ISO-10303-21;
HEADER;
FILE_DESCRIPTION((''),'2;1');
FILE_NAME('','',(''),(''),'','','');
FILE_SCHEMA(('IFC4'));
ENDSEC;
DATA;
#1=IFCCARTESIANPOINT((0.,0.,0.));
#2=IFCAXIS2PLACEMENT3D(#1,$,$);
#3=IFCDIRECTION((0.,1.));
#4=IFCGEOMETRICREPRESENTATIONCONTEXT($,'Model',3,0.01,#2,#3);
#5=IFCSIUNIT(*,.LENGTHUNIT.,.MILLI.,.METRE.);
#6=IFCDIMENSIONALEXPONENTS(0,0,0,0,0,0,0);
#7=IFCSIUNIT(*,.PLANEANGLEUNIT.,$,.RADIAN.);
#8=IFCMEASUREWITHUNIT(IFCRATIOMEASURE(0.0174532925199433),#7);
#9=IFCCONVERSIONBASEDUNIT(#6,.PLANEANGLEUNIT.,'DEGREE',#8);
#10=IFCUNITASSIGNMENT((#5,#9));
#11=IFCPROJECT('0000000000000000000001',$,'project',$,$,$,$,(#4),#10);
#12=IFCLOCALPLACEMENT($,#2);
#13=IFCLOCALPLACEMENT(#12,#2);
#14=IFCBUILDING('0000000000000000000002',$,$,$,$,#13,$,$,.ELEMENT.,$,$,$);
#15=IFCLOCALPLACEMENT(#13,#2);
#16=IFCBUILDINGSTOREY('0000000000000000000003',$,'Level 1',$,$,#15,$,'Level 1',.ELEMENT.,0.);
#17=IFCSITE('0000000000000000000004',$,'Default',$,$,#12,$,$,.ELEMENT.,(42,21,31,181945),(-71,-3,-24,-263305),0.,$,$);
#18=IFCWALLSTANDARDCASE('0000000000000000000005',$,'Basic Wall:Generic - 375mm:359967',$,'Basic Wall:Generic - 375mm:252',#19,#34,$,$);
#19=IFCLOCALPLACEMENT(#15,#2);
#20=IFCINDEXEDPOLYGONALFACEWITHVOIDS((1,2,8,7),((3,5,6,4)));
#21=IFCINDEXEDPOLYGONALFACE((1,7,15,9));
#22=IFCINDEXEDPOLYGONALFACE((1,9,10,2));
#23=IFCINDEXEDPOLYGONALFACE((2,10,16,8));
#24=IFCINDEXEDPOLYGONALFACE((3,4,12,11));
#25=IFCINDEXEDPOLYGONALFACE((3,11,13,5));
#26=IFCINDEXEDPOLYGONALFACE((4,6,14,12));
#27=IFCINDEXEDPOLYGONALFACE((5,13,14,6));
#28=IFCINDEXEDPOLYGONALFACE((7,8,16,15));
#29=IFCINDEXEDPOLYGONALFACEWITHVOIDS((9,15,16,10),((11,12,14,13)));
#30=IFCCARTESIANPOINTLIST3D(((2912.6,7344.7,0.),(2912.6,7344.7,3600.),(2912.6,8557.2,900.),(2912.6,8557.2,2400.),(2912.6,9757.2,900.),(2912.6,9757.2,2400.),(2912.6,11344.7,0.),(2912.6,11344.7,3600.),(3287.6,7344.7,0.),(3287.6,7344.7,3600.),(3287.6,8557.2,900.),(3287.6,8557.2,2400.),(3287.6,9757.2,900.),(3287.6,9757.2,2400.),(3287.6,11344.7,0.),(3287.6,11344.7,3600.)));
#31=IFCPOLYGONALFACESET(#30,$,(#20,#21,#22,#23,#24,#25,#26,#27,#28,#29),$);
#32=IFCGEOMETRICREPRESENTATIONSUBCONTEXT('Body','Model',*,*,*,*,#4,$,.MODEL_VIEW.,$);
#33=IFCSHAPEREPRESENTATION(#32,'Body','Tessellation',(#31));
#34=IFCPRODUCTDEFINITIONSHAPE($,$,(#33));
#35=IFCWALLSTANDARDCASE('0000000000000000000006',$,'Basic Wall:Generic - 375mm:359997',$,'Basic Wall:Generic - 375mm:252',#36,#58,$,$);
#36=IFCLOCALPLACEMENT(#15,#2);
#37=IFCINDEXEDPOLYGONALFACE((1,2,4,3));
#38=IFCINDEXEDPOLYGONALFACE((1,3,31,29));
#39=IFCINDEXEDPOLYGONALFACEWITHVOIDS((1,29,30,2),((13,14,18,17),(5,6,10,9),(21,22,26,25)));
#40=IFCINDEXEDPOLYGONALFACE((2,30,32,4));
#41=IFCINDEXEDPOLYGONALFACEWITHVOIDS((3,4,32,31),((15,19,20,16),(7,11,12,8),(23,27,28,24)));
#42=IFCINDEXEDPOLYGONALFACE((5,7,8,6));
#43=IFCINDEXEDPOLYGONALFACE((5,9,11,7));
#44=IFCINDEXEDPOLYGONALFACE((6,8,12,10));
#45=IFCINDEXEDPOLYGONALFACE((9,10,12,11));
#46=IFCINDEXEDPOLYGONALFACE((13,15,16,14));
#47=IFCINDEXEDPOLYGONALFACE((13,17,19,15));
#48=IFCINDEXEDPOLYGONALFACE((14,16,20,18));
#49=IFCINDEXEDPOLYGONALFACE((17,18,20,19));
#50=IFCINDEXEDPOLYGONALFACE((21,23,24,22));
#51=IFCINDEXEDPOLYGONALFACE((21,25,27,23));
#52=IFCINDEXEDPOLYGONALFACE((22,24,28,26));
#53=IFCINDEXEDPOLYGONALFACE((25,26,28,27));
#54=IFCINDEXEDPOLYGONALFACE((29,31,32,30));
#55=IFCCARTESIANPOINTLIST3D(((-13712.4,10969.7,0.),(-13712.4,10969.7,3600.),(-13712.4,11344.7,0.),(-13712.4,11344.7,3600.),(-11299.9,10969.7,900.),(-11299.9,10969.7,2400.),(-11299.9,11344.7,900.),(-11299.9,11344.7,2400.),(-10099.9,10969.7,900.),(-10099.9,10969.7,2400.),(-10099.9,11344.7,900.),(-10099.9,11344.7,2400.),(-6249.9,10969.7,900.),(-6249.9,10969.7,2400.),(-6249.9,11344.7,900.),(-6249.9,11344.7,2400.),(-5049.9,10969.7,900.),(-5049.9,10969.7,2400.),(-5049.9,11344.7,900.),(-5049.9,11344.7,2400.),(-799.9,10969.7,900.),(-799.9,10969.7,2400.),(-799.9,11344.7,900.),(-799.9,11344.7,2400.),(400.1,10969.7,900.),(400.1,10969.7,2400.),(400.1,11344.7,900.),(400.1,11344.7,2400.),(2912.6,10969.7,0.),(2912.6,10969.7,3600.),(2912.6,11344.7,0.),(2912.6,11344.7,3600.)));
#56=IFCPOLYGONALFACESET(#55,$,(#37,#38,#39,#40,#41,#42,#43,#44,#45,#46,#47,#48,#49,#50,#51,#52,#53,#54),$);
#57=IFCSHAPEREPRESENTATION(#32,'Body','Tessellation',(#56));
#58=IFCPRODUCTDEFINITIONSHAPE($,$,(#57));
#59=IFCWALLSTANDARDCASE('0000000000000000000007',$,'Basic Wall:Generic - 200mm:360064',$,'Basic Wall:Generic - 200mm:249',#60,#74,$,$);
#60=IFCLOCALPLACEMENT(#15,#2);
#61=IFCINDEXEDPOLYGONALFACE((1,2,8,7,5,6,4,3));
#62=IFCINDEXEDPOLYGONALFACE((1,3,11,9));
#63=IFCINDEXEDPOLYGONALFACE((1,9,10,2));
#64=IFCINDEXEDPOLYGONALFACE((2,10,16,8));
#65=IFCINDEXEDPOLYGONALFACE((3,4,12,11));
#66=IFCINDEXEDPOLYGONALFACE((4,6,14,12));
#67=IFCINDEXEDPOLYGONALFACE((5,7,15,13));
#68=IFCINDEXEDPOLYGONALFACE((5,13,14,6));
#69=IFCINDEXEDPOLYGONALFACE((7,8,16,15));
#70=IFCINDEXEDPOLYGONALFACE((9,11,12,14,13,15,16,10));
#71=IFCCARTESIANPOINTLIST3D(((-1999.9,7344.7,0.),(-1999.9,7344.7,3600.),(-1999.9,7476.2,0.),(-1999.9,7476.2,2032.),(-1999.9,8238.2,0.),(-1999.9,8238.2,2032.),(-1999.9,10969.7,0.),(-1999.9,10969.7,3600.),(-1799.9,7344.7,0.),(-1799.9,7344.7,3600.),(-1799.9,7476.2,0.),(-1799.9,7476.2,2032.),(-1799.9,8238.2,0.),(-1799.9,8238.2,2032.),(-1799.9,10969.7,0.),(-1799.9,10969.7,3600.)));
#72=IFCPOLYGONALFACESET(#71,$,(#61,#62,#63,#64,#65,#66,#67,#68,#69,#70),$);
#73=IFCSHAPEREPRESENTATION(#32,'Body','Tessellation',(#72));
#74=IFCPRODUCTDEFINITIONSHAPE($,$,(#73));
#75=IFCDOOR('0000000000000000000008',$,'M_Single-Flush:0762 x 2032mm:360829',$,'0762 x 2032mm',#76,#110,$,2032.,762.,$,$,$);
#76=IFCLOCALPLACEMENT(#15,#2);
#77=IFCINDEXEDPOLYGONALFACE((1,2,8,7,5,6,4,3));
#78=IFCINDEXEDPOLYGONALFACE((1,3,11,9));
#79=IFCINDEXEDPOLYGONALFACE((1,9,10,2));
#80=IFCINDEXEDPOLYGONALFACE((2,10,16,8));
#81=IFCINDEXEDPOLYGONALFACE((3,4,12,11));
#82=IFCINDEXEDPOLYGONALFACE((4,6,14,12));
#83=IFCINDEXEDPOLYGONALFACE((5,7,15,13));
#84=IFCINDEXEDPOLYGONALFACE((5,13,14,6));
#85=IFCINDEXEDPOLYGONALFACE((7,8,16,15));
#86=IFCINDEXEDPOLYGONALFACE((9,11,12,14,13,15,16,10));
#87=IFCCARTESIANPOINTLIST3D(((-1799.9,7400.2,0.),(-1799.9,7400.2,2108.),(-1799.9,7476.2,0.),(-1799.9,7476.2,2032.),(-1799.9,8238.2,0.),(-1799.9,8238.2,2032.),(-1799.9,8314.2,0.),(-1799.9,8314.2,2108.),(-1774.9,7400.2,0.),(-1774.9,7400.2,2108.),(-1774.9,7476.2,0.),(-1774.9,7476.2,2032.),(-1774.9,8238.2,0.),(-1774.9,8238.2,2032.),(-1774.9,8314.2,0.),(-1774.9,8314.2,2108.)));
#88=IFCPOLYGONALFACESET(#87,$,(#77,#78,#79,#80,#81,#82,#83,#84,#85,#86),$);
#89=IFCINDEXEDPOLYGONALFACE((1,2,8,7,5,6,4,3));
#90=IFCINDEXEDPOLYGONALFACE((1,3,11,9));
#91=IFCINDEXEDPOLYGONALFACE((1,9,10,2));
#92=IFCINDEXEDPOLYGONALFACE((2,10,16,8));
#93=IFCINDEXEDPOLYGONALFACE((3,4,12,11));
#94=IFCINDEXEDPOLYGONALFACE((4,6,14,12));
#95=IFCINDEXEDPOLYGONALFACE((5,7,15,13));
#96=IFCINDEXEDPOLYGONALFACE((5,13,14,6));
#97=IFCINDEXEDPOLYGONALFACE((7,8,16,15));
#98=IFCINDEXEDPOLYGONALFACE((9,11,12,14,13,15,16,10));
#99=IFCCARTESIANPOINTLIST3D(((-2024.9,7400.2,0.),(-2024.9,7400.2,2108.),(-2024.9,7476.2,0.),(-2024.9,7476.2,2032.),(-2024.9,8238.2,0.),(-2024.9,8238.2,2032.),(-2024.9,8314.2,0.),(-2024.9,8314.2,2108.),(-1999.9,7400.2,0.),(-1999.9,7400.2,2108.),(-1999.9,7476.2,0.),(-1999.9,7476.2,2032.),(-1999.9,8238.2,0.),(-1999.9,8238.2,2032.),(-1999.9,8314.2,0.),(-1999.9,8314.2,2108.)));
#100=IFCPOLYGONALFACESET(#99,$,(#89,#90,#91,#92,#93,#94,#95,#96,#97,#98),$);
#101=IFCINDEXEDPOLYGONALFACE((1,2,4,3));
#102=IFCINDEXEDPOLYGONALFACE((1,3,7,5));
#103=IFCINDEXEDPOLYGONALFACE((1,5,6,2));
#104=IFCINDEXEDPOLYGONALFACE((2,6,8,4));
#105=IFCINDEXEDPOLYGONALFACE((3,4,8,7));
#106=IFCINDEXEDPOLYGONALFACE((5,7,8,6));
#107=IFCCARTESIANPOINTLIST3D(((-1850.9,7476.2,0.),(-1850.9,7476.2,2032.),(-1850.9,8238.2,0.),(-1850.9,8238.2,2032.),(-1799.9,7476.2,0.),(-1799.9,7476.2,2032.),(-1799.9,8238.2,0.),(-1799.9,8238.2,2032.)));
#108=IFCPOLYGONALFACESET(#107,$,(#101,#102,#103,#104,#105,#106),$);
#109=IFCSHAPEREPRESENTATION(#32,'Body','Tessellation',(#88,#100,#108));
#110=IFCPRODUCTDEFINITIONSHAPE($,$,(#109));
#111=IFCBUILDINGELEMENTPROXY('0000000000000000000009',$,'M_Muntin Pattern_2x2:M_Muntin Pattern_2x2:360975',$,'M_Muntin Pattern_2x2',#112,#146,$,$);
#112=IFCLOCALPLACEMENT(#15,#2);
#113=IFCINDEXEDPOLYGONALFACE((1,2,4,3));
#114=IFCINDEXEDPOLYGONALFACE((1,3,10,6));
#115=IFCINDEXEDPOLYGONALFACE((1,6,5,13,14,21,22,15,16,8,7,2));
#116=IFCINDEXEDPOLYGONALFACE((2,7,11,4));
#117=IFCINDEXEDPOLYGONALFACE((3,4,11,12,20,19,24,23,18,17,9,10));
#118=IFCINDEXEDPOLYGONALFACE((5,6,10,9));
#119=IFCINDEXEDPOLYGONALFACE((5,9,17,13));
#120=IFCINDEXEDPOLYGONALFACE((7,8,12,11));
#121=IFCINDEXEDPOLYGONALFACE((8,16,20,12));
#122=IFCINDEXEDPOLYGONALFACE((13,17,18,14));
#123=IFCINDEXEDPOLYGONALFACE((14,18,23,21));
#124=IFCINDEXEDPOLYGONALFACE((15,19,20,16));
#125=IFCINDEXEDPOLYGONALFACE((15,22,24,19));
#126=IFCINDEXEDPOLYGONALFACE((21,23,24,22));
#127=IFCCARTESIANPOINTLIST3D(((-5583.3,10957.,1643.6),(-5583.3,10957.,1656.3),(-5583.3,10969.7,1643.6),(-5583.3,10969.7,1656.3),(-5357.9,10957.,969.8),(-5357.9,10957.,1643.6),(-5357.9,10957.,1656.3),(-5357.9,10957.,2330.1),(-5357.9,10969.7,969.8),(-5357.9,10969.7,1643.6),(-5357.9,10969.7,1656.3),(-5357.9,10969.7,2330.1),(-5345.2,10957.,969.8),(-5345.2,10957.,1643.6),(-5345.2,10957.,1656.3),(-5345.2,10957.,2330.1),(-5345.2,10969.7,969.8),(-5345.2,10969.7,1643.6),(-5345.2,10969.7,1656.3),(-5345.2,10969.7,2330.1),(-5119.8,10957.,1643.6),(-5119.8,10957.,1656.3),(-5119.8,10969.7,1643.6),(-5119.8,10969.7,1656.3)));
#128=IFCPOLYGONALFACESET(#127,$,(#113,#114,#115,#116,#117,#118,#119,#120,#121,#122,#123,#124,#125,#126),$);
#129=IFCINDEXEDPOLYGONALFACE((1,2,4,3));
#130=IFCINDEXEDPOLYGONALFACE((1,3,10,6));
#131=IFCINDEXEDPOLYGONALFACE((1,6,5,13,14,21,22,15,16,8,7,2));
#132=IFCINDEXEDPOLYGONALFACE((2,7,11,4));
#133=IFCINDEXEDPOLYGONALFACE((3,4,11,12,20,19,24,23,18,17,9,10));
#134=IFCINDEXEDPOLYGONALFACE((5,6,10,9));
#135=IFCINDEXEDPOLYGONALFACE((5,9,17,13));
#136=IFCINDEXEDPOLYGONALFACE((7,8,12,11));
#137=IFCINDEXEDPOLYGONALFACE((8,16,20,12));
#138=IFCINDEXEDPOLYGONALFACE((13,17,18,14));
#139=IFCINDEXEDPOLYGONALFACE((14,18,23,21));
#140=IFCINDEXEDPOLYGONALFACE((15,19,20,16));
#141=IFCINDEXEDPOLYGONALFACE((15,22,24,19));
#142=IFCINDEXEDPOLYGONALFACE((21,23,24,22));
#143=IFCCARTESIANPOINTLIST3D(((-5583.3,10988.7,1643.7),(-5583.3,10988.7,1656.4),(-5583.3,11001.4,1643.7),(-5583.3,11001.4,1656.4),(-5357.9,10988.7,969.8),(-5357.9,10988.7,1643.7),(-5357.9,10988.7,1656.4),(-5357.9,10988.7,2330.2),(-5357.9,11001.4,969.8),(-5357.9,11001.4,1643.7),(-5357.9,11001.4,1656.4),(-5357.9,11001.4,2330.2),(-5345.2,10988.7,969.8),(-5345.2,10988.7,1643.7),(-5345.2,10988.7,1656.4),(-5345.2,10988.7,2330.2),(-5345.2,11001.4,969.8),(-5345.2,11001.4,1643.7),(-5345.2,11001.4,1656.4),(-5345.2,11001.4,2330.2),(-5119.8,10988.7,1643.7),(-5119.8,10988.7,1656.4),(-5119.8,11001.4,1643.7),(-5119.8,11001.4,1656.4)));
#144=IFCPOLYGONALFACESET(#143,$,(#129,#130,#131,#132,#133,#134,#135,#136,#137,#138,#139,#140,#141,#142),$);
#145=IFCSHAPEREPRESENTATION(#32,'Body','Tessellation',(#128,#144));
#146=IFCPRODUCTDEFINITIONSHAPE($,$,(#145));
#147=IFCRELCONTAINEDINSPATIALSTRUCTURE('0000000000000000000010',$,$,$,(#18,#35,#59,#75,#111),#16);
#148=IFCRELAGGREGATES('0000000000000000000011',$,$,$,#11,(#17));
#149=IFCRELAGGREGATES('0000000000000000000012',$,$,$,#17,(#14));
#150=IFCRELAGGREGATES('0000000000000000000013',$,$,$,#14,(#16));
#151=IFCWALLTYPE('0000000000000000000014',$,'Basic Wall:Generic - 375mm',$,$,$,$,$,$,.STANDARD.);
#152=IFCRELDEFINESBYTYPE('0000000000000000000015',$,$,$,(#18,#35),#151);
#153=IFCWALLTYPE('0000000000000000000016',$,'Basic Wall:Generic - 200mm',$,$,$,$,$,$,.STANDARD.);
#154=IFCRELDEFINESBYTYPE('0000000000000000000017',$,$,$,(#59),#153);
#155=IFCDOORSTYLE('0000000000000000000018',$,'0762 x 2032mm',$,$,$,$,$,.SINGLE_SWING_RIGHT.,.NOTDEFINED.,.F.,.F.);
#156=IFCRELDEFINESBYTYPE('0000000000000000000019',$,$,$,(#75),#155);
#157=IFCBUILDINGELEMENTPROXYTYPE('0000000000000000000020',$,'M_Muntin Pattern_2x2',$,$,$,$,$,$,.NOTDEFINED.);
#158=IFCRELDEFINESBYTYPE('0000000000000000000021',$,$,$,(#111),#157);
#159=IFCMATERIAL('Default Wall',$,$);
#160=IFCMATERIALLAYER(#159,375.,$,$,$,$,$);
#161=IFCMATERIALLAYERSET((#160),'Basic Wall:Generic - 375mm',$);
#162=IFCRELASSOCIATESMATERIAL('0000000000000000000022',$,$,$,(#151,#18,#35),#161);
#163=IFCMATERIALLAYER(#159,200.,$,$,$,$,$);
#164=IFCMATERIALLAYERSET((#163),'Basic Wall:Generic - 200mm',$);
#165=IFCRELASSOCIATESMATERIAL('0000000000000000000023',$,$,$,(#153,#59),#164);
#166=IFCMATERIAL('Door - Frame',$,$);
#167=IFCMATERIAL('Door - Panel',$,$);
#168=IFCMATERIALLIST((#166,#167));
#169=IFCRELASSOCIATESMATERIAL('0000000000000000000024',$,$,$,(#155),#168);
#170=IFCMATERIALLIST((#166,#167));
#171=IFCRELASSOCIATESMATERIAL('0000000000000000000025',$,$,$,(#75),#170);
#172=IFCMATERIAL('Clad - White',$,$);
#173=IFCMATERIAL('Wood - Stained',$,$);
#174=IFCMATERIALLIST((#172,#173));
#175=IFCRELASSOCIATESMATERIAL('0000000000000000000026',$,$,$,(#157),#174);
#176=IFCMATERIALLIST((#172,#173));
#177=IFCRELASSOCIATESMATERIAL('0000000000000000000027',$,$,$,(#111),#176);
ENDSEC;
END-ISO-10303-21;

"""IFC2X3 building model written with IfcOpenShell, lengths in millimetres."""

from ifc_helpers import new_model, entity, si_unit, converted_unit, direction, frame, frame_2d, origin, place, context, subcontext, project, spatial, polyline, rectangle, outline, extrude, clip, bounded_halfspace, source, transform, mapped, material, material_list, layer, layer_set, layer_usage, type_object, type_shapes, element, fill, save


model = new_model("IFC2X3")

# Units and contexts
model_context = context("Model", 3, precision=0.01, world=origin(), true_north=direction((0.0, 1.0)))
body_context = subcontext(model_context, "Body", "Model", "MODEL_VIEW")
ifc_project = project(units=[si_unit("LENGTHUNIT", "METRE", prefix="MILLI"), converted_unit("PLANEANGLEUNIT", "DEGREE", entity("IfcRatioMeasure", 0.0174532925199433), si_unit("PLANEANGLEUNIT", "RADIAN"), dimensions=[0, 0, 0, 0, 0, 0, 0])], contexts=[model_context])

# Site, building, storey
site_placement = place(None, origin())
site = spatial("IfcSite", under=ifc_project, at=site_placement, Name="Default", CompositionType="ELEMENT", RefLatitude=(42, 21, 31, 181945), RefLongitude=(-71, -3, -24, -263305), RefElevation=0.0)
building_placement = place(site_placement, origin())
building = spatial("IfcBuilding", under=site, at=building_placement, CompositionType="ELEMENT")
storey_placement = place(building_placement, origin())
storey = spatial("IfcBuildingStorey", under=building, at=storey_placement, Name="Level 1", LongName="Level 1", CompositionType="ELEMENT", Elevation=0.0)

# Wall, opening
ifc_material_1 = material(Name="Default Wall")
ifc_layer_1 = layer(ifc_material_1, 375.0)
ifc_layer_set_1 = layer_set([ifc_layer_1], Name="Basic Wall:Generic - 375mm")
ifc_layer_usage_1 = layer_usage(ifc_layer_set_1, "AXIS2", "NEGATIVE", 187.5)
wall_type_1 = type_object("IfcWallType", Name="Basic Wall:Generic - 375mm", PredefinedType="STANDARD", material=ifc_layer_set_1)
wall_1_placement = place(storey_placement, frame((3100.1, 7344.7, 0.0), z_axis=(0.0, 0.0, 1.0), x_axis=(0.0, 1.0, 0.0)))
wall_1 = element("IfcWallStandardCase", 1, at=wall_1_placement, inside=storey, type_object=wall_type_1, material=ifc_layer_usage_1, Name="Basic Wall:Generic - 375mm:359967", ObjectType="Basic Wall:Generic - 375mm:252", context=body_context, shape_type="Clipping", body=[
    clip(extrude(rectangle(XDim=4000.0, YDim=375.0, at=frame_2d((2000.0, 0.0), x_axis=(-1.0, 0.0))), origin(), (0.0, 0.0, 1.0), 3600.0), bounded_halfspace(frame((0.0, -187.5, 3600.0), z_axis=(0.0, 0.0, -1.0), x_axis=(0.0, -1.0, 0.0)), True, frame((0.0, -187.5, 3600.0)), polyline([(0.0, 0.0), (4000.0, 0.0), (4000.0, 375.0), (3625.0, 375.0), (0.0, 375.0), (0.0, 0.0)]))),
])
opening_1_placement = place(wall_1_placement, frame((1212.5, -187.5, 900.0)))
element("IfcOpeningElement", 2, at=opening_1_placement, cuts=wall_1, ObjectType="Opening", context=body_context, shape_type="SweptSolid", body=[
    extrude(rectangle(XDim=1500.0, YDim=1200.0, at=frame_2d((750.0, 600.0), x_axis=(-1.0, 0.0))), frame((0.0, 0.0, 0.0), z_axis=(0.0, 1.0, 0.0), x_axis=(0.0, 0.0, 1.0)), (0.0, 0.0, 1.0), 375.0),
])

# Wall, openings
ifc_layer_usage_2 = layer_usage(ifc_layer_set_1, "AXIS2", "NEGATIVE", 187.5)
wall_2_placement = place(storey_placement, frame((2912.6, 11157.2, 0.0), z_axis=(0.0, 0.0, 1.0), x_axis=(-1.0, 0.0, 0.0)))
wall_2 = element("IfcWallStandardCase", 3, at=wall_2_placement, inside=storey, type_object=wall_type_1, material=ifc_layer_usage_2, Name="Basic Wall:Generic - 375mm:359997", ObjectType="Basic Wall:Generic - 375mm:252", context=body_context, shape_type="Clipping", body=[
    clip(extrude(rectangle(XDim=16625.0, YDim=375.0, at=frame_2d((8312.5, 0.0), x_axis=(-1.0, 0.0))), origin(), (0.0, 0.0, 1.0), 3600.0), bounded_halfspace(frame((0.0, -187.5, 3600.0), z_axis=(0.0, 0.0, -1.0), x_axis=(-1.0, 0.0, 0.0)), True, frame((0.0, -187.5, 3600.0)), polyline([(0.0, 0.0), (16625.0, 0.0), (16625.0, 375.0), (12412.5, 375.0), (12212.5, 375.0), (4912.5, 375.0), (4712.5, 375.0), (0.0, 375.0), (0.0, 0.0)]))),
])
opening_2_placement = place(wall_2_placement, frame((7962.5, -187.5, 900.0)))
element("IfcOpeningElement", 4, at=opening_2_placement, cuts=wall_2, ObjectType="Opening", context=body_context, shape_type="SweptSolid", body=[
    extrude(rectangle(XDim=1500.0, YDim=1200.0, at=frame_2d((750.0, 600.0), x_axis=(-1.0, 0.0))), frame((0.0, 0.0, 0.0), z_axis=(0.0, 1.0, 0.0), x_axis=(0.0, 0.0, 1.0)), (0.0, 0.0, 1.0), 375.0),
])
opening_3_placement = place(wall_2_placement, frame((2512.5, -187.5, 900.0)))
element("IfcOpeningElement", 5, at=opening_3_placement, cuts=wall_2, ObjectType="Opening", context=body_context, shape_type="SweptSolid", body=[
    extrude(rectangle(XDim=1500.0, YDim=1200.0, at=frame_2d((750.0, 600.0), x_axis=(-1.0, 0.0))), frame((0.0, 0.0, 0.0), z_axis=(0.0, 1.0, 0.0), x_axis=(0.0, 0.0, 1.0)), (0.0, 0.0, 1.0), 375.0),
])
opening_4_placement = place(wall_2_placement, frame((13012.5, -187.5, 900.0)))
element("IfcOpeningElement", 6, at=opening_4_placement, cuts=wall_2, ObjectType="Opening", context=body_context, shape_type="SweptSolid", body=[
    extrude(rectangle(XDim=1500.0, YDim=1200.0, at=frame_2d((750.0, 600.0), x_axis=(-1.0, 0.0))), frame((0.0, 0.0, 0.0), z_axis=(0.0, 1.0, 0.0), x_axis=(0.0, 0.0, 1.0)), (0.0, 0.0, 1.0), 375.0),
])

# Wall, opening, door
ifc_layer_2 = layer(ifc_material_1, 200.0)
ifc_layer_set_2 = layer_set([ifc_layer_2], Name="Basic Wall:Generic - 200mm")
ifc_layer_usage_3 = layer_usage(ifc_layer_set_2, "AXIS2", "NEGATIVE", 100.0)
wall_type_2 = type_object("IfcWallType", Name="Basic Wall:Generic - 200mm", PredefinedType="STANDARD", material=ifc_layer_set_2)
wall_3_placement = place(storey_placement, frame((-1899.9, 10969.7, 0.0), z_axis=(0.0, 0.0, 1.0), x_axis=(0.0, -1.0, 0.0)))
wall_3 = element("IfcWallStandardCase", 7, at=wall_3_placement, inside=storey, type_object=wall_type_2, material=ifc_layer_usage_3, Name="Basic Wall:Generic - 200mm:360064", ObjectType="Basic Wall:Generic - 200mm:249", context=body_context, shape_type="Clipping", body=[
    clip(extrude(rectangle(XDim=3625.0, YDim=200.0, at=frame_2d((1812.5, 0.0), x_axis=(-1.0, 0.0))), origin(), (0.0, 0.0, 1.0), 3600.0), bounded_halfspace(frame((0.0, -100.0, 3600.0), z_axis=(0.0, 0.0, -1.0), x_axis=(0.0, 1.0, 0.0)), True, frame((0.0, -100.0, 3600.0)), polyline([(0.0, 0.0), (3625.0, 0.0), (3625.0, 200.0), (0.0, 200.0), (0.0, 0.0)]))),
])
opening_5_placement = place(wall_3_placement, frame((2731.5, -100.0, 0.0)))
opening_5 = element("IfcOpeningElement", 8, at=opening_5_placement, cuts=wall_3, ObjectType="Opening", context=body_context, shape_type="SweptSolid", body=[
    extrude(rectangle(XDim=762.0, YDim=2032.0, at=frame_2d((1016.0, 381.0), x_axis=(0.0, 1.0))), frame((0.0, 0.0, 0.0), z_axis=(0.0, 1.0, 0.0), x_axis=(0.0, 0.0, 1.0)), (0.0, 0.0, 1.0), 200.0),
])
ifc_material_2 = material(Name="Door - Frame")
ifc_material_3 = material(Name="Door - Panel")
ifc_material_list_1 = material_list([ifc_material_2, ifc_material_3])
ifc_material_list_2 = material_list([ifc_material_2, ifc_material_3])
door_style = type_object("IfcDoorStyle", Name="0762 x 2032mm", ConstructionType="NOTDEFINED", OperationType="SINGLE_SWING_RIGHT", ParameterTakesPrecedence=False, Sizeable=False, material=ifc_material_list_2)
shared_shape_1 = source(origin(), body_context, "Body", "SweptSolid", [
    extrude(outline(polyline([(-457.0, -1073.0), (457.0, -1073.0), (457.0, 1035.0), (381.0, 1035.0), (381.0, -997.0), (-381.0, -997.0), (-381.0, 1035.0), (-457.0, 1035.0), (-457.0, -1073.0)])), frame((381.0, 200.0, 1035.0), z_axis=(0.0, 1.0, 0.0), x_axis=(1.0, 0.0, 0.0)), (0.0, 0.0, 1.0), 25.0),
    extrude(outline(polyline([(-1073.0, -457.0), (1035.0, -457.0), (1035.0, -381.0), (-997.0, -381.0), (-997.0, 381.0), (1035.0, 381.0), (1035.0, 457.0), (-1073.0, 457.0), (-1073.0, -457.0)])), frame((381.0, -25.0, 1035.0), z_axis=(0.0, 1.0, 0.0), x_axis=(0.0, 0.0, -1.0)), (0.0, 0.0, 1.0), 25.0),
    extrude(rectangle(XDim=51.0, YDim=762.0, at=frame_2d((0.0, 0.0), x_axis=(1.0, 0.0))), frame((381.0, 174.5, 0.0), z_axis=(0.0, 0.0, 1.0), x_axis=(0.0, 1.0, 0.0)), (0.0, 0.0, 1.0), 2032.0),
])
type_shapes(door_style, [shared_shape_1])
door_placement = place(opening_5_placement, origin())
door = element("IfcDoor", 9, at=door_placement, inside=storey, type_object=door_style, material=ifc_material_list_1, Name="M_Single-Flush:0762 x 2032mm:360829", ObjectType="0762 x 2032mm", OverallHeight=2032.0, OverallWidth=762.0, context=body_context, shape_type="MappedRepresentation", body=[
    mapped(shared_shape_1, transform((0.0, 0.0, 0.0), scale=1.0)),
])
fill(opening_5, door)

# Building element proxy
ifc_material_4 = material(Name="Clad - White")
ifc_material_5 = material(Name="Wood - Stained")
ifc_material_list_3 = material_list([ifc_material_4, ifc_material_5])
ifc_material_list_4 = material_list([ifc_material_4, ifc_material_5])
building_element_proxy_type_1 = type_object("IfcBuildingElementProxyType", Name="M_Muntin Pattern_2x2", PredefinedType="NOTDEFINED", material=ifc_material_list_4)
shared_shape_2 = source(origin(), body_context, "Body", "SweptSolid", [
    extrude(outline(polyline([(6.4, -6.4), (680.1, -6.4), (680.1, 6.3), (6.4, 6.3), (6.4, 231.7), (-6.3, 231.7), (-6.3, 6.3), (-680.2, 6.3), (-680.2, -6.4), (-6.3, -6.4), (-6.3, -231.7), (6.4, -231.7), (6.4, -6.4)])), frame((0.0, 9.5, 680.1), z_axis=(0.0, 1.0, 0.0), x_axis=(0.0, 0.0, 1.0)), (0.0, 0.0, 1.0), 12.7),
    extrude(outline(polyline([(6.4, -6.4), (680.2, -6.4), (680.2, 6.3), (6.4, 6.3), (6.4, 231.7), (-6.3, 231.7), (-6.3, 6.3), (-680.2, 6.3), (-680.2, -6.4), (-6.3, -6.4), (-6.3, -231.7), (6.4, -231.7), (6.4, -6.4)])), frame((0.0, -22.2, 680.2), z_axis=(0.0, 1.0, 0.0), x_axis=(0.0, 0.0, 1.0)), (0.0, 0.0, 1.0), 12.7),
])
type_shapes(building_element_proxy_type_1, [shared_shape_2])
proxy_1_placement = place(storey_placement, frame((-5351.5, 10979.2, 969.8), z_axis=(0.0, 0.0, 1.0), x_axis=(-1.0, 0.0, 0.0)))
element("IfcBuildingElementProxy", 10, at=proxy_1_placement, inside=storey, type_object=building_element_proxy_type_1, material=ifc_material_list_3, Name="M_Muntin Pattern_2x2:M_Muntin Pattern_2x2:360975", ObjectType="M_Muntin Pattern_2x2", context=body_context, shape_type="MappedRepresentation", body=[
    mapped(shared_shape_2, transform((0.0, 0.0, 0.0), scale=1.0)),
])

save(model, "model.ifc")
